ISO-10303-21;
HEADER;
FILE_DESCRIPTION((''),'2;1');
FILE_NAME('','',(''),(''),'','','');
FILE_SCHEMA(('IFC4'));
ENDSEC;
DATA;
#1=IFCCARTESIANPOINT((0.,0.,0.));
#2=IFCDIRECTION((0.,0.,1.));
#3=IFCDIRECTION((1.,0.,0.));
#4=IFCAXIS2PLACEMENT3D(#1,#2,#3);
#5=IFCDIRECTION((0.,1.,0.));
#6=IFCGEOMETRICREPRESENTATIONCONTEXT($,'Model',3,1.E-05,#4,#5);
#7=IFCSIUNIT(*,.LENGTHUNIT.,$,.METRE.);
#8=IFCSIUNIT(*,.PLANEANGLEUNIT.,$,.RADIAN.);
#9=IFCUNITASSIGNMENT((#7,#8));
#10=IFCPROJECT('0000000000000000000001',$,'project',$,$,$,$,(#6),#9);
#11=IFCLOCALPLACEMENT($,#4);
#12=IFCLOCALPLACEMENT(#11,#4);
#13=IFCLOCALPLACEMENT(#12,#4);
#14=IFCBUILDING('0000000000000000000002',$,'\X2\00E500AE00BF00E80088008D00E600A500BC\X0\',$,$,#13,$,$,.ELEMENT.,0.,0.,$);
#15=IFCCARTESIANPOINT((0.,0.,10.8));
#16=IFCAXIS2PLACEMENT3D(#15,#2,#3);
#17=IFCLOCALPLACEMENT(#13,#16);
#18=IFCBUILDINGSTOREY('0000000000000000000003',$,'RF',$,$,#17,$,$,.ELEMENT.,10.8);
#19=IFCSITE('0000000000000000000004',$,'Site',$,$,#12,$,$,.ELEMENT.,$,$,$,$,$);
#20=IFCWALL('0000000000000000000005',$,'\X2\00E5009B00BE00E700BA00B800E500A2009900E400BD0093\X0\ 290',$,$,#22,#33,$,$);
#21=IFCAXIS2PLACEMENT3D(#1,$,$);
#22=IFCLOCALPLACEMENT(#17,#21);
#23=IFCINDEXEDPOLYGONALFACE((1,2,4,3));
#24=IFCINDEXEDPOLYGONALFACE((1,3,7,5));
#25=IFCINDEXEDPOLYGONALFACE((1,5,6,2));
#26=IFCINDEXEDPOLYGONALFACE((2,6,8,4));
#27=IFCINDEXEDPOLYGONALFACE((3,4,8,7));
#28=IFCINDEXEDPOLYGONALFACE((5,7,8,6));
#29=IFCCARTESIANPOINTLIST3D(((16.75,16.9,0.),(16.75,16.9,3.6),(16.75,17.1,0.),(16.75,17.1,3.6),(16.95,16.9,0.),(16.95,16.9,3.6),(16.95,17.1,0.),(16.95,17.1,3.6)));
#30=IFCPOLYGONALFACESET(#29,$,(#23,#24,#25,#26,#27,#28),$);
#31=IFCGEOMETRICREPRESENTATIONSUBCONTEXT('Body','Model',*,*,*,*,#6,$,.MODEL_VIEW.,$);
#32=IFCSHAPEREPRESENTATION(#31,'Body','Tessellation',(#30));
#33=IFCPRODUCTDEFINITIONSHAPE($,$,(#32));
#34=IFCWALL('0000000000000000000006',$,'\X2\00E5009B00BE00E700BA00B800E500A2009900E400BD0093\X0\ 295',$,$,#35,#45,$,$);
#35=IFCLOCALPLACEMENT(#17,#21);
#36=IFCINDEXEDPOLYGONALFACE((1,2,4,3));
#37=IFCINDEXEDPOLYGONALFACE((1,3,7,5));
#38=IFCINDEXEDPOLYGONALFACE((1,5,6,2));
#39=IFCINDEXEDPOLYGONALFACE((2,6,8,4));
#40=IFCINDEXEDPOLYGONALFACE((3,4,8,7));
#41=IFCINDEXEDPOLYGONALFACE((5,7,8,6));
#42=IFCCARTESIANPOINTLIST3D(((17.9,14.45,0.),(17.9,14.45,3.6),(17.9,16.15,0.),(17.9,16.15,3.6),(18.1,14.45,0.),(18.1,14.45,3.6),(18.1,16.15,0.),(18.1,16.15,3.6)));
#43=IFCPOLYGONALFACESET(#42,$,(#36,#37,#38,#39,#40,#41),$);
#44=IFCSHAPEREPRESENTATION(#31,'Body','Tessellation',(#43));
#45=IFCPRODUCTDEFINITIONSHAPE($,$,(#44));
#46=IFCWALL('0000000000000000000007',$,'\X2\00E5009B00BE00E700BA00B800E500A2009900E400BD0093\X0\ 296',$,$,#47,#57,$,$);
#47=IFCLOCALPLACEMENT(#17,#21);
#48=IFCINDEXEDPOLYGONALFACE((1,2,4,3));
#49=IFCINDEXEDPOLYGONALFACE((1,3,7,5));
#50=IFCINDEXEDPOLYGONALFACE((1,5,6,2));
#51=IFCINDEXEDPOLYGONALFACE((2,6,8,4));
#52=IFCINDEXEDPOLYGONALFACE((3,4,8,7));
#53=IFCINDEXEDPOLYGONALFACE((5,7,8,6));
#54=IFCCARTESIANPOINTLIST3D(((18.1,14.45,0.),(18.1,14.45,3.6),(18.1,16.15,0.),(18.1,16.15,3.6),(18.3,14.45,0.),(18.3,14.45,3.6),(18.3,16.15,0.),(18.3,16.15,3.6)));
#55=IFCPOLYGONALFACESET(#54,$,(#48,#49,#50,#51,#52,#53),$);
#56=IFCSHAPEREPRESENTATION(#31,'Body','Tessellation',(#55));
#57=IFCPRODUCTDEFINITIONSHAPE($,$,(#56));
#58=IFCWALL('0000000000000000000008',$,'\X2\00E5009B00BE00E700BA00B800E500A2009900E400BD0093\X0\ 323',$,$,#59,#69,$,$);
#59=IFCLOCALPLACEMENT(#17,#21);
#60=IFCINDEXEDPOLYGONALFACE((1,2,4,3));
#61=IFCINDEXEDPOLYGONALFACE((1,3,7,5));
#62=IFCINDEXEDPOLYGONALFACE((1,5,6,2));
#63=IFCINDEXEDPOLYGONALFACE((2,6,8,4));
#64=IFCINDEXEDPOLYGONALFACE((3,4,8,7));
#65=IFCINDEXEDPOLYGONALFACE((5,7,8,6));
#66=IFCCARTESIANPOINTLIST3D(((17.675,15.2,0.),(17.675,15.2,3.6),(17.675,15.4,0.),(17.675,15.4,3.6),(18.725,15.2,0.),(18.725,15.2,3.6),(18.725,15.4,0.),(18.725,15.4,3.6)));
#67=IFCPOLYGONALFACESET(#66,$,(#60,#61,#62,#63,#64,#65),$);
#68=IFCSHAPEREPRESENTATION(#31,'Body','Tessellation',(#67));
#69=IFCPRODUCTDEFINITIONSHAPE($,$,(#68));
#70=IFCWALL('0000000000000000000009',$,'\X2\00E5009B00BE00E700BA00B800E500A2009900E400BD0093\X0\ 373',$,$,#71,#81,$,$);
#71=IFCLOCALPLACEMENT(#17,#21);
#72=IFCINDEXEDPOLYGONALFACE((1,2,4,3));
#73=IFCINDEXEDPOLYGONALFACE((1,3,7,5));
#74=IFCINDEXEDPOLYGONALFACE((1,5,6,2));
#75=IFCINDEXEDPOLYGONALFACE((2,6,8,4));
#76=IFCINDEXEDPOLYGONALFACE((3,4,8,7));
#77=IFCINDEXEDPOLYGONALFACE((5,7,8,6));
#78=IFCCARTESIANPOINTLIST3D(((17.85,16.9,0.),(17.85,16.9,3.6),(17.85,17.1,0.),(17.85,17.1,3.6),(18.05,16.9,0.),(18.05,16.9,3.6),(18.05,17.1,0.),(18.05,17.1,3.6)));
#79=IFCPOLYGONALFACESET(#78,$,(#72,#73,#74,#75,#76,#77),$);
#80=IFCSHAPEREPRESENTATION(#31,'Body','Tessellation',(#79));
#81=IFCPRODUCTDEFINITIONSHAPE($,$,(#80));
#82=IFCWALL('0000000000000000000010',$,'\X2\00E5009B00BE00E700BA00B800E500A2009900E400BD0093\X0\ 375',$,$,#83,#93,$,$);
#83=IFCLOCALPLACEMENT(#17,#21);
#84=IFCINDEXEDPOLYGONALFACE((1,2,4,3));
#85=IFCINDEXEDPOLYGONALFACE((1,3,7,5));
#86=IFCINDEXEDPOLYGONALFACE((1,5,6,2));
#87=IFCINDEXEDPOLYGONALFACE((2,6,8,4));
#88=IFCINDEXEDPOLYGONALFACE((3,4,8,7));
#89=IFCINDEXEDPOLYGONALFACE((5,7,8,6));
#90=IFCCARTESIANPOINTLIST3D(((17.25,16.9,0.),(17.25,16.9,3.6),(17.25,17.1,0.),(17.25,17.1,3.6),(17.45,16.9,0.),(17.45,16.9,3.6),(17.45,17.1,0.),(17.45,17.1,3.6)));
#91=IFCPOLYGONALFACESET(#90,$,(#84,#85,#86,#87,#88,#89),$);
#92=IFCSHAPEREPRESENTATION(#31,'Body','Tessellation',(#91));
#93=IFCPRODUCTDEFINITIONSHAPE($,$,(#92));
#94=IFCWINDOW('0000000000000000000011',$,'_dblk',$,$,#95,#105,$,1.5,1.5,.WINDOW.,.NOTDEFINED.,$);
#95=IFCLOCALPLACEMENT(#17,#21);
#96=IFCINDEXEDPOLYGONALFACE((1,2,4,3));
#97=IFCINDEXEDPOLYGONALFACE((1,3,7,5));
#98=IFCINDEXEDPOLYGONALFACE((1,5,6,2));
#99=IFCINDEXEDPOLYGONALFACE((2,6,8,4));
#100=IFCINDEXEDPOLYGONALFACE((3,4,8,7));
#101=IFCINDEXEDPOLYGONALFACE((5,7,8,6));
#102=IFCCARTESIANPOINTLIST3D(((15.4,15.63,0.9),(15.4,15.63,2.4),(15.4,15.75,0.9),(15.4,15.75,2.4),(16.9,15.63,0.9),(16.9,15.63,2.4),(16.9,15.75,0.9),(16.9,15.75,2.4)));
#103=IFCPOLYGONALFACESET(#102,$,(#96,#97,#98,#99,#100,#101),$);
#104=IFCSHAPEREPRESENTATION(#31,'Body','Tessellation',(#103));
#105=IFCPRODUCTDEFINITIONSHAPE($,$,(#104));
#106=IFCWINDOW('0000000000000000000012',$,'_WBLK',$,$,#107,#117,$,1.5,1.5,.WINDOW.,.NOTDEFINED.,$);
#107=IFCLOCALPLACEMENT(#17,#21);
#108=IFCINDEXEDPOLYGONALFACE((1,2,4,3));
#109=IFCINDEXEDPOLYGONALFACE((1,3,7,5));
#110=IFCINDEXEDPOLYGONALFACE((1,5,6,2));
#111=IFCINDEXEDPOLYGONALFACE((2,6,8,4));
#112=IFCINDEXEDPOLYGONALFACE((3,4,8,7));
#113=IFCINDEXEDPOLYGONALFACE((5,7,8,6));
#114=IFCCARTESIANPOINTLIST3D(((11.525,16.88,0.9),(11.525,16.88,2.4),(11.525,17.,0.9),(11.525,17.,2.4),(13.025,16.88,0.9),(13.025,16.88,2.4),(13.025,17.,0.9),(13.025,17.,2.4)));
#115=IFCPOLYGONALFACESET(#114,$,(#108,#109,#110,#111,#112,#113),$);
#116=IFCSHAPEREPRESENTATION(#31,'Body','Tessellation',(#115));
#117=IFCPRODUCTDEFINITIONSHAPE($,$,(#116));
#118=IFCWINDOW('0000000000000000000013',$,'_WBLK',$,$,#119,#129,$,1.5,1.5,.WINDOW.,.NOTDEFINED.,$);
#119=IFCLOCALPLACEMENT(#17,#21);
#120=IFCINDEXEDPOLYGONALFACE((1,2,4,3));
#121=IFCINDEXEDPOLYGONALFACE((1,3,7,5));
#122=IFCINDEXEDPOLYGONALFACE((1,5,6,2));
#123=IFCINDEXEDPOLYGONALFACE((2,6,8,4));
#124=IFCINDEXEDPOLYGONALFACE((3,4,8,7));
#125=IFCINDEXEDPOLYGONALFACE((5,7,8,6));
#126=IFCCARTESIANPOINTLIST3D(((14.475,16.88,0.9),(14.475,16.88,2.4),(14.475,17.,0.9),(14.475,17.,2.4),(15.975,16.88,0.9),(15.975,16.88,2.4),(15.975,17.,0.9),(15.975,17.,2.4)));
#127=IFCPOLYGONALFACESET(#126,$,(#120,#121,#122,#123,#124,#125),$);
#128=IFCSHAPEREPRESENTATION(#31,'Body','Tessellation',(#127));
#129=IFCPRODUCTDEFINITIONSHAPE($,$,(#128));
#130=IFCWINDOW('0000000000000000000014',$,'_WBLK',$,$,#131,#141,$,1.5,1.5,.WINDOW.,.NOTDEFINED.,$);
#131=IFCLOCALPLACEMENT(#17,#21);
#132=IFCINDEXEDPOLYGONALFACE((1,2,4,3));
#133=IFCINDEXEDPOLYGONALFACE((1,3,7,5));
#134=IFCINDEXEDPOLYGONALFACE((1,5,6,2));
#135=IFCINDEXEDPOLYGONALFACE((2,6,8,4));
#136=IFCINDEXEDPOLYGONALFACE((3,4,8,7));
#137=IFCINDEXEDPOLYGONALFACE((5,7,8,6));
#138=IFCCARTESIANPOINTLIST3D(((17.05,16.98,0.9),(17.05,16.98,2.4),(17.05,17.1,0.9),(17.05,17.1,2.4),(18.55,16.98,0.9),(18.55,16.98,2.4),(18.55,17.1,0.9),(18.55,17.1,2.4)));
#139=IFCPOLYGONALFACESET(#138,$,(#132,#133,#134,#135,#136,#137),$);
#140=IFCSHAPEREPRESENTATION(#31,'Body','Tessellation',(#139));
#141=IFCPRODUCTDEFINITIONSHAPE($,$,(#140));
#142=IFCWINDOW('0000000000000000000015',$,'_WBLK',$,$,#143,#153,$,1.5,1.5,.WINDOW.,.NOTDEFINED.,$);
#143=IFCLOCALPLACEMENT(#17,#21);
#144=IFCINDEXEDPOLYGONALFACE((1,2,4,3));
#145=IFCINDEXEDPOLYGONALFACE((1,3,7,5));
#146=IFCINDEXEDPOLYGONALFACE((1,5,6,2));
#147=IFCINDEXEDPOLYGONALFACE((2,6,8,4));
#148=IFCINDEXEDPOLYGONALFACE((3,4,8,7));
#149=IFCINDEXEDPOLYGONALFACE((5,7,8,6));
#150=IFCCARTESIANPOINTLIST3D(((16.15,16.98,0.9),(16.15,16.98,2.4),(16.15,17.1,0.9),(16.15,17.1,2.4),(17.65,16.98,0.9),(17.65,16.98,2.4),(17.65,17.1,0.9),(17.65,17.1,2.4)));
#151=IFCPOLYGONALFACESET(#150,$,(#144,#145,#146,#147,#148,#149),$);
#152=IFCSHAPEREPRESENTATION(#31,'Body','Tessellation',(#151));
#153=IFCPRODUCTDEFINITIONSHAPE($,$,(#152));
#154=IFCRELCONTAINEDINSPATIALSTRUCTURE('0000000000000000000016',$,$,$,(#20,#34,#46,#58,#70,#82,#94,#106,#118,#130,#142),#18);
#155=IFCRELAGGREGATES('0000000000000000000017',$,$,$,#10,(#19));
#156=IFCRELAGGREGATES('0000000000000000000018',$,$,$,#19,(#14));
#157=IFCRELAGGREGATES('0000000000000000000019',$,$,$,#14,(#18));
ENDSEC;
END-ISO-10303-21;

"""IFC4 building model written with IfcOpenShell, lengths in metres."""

from ifc_helpers import new_model, si_unit, direction, frame, frame_2d, origin_with_axes, place, context, subcontext, project, spatial, rectangle, extrude, element, save


model = new_model("IFC4")

# Units and contexts
model_context = context("Model", 3, precision=1e-05, world=origin_with_axes(), true_north=direction((0.0, 1.0, 0.0)))
body_context = subcontext(model_context, "Body", "Model", "MODEL_VIEW")
ifc_project = project(units=[si_unit("LENGTHUNIT", "METRE"), si_unit("PLANEANGLEUNIT", "RADIAN")], contexts=[model_context])

# Site, building, storey
placement = place(None, origin_with_axes())
site_placement = place(placement, origin_with_axes())
site = spatial("IfcSite", under=ifc_project, at=site_placement, Name="Site", CompositionType="ELEMENT")
building_placement = place(site_placement, origin_with_axes())
building = spatial("IfcBuilding", under=site, at=building_placement, Name="å®¿è\u0088\u008dæ¥¼", CompositionType="ELEMENT", ElevationOfRefHeight=0.0, ElevationOfTerrain=0.0)
storey_placement = place(building_placement, frame((0.0, 0.0, 10.8), z_axis=(0.0, 0.0, 1.0), x_axis=(1.0, 0.0, 0.0)))
storey = spatial("IfcBuildingStorey", under=building, at=storey_placement, Name="RF", CompositionType="ELEMENT", Elevation=10.8)

# Walls
wall_1_placement = place(storey_placement, frame((16.85, 17.0, 0.0), z_axis=(0.0, 0.0, 1.0), x_axis=(0.0, 1.0, 0.0)))
element("IfcWall", 1, at=wall_1_placement, inside=storey, Name="å\u009b¾çº¸å¢\u0099ä½\u0093 290", context=body_context, shape_type="SweptSolid", body=[
    extrude(rectangle(XDim=0.2, YDim=0.2, at=frame_2d((0.0, 0.0), x_axis=(1.0, 0.0, 0.0))), frame((0.0, 0.0, 0.0), z_axis=(0.0, 0.0, 1.0)), (0.0, 0.0, 1.0), 3.6),
])
for number, where, z_axis, x_axis, name in (
    (2, (18.0, 15.3, 0.0), (0.0, 0.0, 1.0), (0.0, 1.0, 0.0), "å\u009b¾çº¸å¢\u0099ä½\u0093 295"),
    (3, (18.2, 15.3, 0.0), (0.0, 0.0, 1.0), (0.0, 1.0, 0.0), "å\u009b¾çº¸å¢\u0099ä½\u0093 296"),
):
    element("IfcWall", number, at=place(storey_placement, frame(where, z_axis=z_axis, x_axis=x_axis)), inside=storey, Name=name, context=body_context, shape_type="SweptSolid", body=[
        extrude(rectangle(XDim=1.7, YDim=0.2, at=frame_2d((0.0, 0.0), x_axis=(1.0, 0.0, 0.0))), frame((0.0, 0.0, 0.0), z_axis=(0.0, 0.0, 1.0)), (0.0, 0.0, 1.0), 3.6),
    ])
wall_2_placement = place(storey_placement, frame((18.2, 15.3, 0.0), z_axis=(0.0, 0.0, 1.0), x_axis=(1.0, 0.0, 0.0)))
element("IfcWall", 4, at=wall_2_placement, inside=storey, Name="å\u009b¾çº¸å¢\u0099ä½\u0093 323", context=body_context, shape_type="SweptSolid", body=[
    extrude(rectangle(XDim=1.05, YDim=0.2, at=frame_2d((0.0, 0.0), x_axis=(1.0, 0.0, 0.0))), frame((0.0, 0.0, 0.0), z_axis=(0.0, 0.0, 1.0)), (0.0, 0.0, 1.0), 3.6),
])
for number, where, z_axis, x_axis, name in (
    (5, (17.95, 17.0, 0.0), (0.0, 0.0, 1.0), (1.0, 0.0, 0.0), "å\u009b¾çº¸å¢\u0099ä½\u0093 373"),
    (6, (17.35, 17.0, 0.0), (0.0, 0.0, 1.0), (0.0, 1.0, 0.0), "å\u009b¾çº¸å¢\u0099ä½\u0093 375"),
):
    element("IfcWall", number, at=place(storey_placement, frame(where, z_axis=z_axis, x_axis=x_axis)), inside=storey, Name=name, context=body_context, shape_type="SweptSolid", body=[
        extrude(rectangle(XDim=0.2, YDim=0.2, at=frame_2d((0.0, 0.0), x_axis=(1.0, 0.0, 0.0))), frame((0.0, 0.0, 0.0), z_axis=(0.0, 0.0, 1.0)), (0.0, 0.0, 1.0), 3.6),
    ])

# Windows
for number, where, z_axis, x_axis, name in (
    (7, (16.15, 15.69, 0.9), (0.0, 0.0, 1.0), (1.0, 0.0, 0.0), "_dblk"),
    (8, (12.275, 16.94, 0.9), (0.0, 0.0, 1.0), (1.0, 0.0, 0.0), "_WBLK"),
    (9, (15.225, 16.94, 0.9), (0.0, 0.0, 1.0), (1.0, 0.0, 0.0), "_WBLK"),
    (10, (17.8, 17.04, 0.9), (0.0, 0.0, 1.0), (1.0, 0.0, 0.0), "_WBLK"),
    (11, (16.9, 17.04, 0.9), (0.0, 0.0, 1.0), (1.0, 0.0, 0.0), "_WBLK"),
):
    element("IfcWindow", number, at=place(storey_placement, frame(where, z_axis=z_axis, x_axis=x_axis)), inside=storey, Name=name, OverallHeight=1.5, OverallWidth=1.5, PartitioningType="NOTDEFINED", PredefinedType="WINDOW", context=body_context, shape_type="SweptSolid", body=[
        extrude(rectangle(XDim=1.5, YDim=0.12, at=frame_2d((0.0, 0.0), x_axis=(1.0, 0.0, 0.0))), frame((0.0, 0.0, 0.0), z_axis=(0.0, 0.0, 1.0)), (0.0, 0.0, 1.0), 1.5),
    ])

save(model, "model.ifc")
